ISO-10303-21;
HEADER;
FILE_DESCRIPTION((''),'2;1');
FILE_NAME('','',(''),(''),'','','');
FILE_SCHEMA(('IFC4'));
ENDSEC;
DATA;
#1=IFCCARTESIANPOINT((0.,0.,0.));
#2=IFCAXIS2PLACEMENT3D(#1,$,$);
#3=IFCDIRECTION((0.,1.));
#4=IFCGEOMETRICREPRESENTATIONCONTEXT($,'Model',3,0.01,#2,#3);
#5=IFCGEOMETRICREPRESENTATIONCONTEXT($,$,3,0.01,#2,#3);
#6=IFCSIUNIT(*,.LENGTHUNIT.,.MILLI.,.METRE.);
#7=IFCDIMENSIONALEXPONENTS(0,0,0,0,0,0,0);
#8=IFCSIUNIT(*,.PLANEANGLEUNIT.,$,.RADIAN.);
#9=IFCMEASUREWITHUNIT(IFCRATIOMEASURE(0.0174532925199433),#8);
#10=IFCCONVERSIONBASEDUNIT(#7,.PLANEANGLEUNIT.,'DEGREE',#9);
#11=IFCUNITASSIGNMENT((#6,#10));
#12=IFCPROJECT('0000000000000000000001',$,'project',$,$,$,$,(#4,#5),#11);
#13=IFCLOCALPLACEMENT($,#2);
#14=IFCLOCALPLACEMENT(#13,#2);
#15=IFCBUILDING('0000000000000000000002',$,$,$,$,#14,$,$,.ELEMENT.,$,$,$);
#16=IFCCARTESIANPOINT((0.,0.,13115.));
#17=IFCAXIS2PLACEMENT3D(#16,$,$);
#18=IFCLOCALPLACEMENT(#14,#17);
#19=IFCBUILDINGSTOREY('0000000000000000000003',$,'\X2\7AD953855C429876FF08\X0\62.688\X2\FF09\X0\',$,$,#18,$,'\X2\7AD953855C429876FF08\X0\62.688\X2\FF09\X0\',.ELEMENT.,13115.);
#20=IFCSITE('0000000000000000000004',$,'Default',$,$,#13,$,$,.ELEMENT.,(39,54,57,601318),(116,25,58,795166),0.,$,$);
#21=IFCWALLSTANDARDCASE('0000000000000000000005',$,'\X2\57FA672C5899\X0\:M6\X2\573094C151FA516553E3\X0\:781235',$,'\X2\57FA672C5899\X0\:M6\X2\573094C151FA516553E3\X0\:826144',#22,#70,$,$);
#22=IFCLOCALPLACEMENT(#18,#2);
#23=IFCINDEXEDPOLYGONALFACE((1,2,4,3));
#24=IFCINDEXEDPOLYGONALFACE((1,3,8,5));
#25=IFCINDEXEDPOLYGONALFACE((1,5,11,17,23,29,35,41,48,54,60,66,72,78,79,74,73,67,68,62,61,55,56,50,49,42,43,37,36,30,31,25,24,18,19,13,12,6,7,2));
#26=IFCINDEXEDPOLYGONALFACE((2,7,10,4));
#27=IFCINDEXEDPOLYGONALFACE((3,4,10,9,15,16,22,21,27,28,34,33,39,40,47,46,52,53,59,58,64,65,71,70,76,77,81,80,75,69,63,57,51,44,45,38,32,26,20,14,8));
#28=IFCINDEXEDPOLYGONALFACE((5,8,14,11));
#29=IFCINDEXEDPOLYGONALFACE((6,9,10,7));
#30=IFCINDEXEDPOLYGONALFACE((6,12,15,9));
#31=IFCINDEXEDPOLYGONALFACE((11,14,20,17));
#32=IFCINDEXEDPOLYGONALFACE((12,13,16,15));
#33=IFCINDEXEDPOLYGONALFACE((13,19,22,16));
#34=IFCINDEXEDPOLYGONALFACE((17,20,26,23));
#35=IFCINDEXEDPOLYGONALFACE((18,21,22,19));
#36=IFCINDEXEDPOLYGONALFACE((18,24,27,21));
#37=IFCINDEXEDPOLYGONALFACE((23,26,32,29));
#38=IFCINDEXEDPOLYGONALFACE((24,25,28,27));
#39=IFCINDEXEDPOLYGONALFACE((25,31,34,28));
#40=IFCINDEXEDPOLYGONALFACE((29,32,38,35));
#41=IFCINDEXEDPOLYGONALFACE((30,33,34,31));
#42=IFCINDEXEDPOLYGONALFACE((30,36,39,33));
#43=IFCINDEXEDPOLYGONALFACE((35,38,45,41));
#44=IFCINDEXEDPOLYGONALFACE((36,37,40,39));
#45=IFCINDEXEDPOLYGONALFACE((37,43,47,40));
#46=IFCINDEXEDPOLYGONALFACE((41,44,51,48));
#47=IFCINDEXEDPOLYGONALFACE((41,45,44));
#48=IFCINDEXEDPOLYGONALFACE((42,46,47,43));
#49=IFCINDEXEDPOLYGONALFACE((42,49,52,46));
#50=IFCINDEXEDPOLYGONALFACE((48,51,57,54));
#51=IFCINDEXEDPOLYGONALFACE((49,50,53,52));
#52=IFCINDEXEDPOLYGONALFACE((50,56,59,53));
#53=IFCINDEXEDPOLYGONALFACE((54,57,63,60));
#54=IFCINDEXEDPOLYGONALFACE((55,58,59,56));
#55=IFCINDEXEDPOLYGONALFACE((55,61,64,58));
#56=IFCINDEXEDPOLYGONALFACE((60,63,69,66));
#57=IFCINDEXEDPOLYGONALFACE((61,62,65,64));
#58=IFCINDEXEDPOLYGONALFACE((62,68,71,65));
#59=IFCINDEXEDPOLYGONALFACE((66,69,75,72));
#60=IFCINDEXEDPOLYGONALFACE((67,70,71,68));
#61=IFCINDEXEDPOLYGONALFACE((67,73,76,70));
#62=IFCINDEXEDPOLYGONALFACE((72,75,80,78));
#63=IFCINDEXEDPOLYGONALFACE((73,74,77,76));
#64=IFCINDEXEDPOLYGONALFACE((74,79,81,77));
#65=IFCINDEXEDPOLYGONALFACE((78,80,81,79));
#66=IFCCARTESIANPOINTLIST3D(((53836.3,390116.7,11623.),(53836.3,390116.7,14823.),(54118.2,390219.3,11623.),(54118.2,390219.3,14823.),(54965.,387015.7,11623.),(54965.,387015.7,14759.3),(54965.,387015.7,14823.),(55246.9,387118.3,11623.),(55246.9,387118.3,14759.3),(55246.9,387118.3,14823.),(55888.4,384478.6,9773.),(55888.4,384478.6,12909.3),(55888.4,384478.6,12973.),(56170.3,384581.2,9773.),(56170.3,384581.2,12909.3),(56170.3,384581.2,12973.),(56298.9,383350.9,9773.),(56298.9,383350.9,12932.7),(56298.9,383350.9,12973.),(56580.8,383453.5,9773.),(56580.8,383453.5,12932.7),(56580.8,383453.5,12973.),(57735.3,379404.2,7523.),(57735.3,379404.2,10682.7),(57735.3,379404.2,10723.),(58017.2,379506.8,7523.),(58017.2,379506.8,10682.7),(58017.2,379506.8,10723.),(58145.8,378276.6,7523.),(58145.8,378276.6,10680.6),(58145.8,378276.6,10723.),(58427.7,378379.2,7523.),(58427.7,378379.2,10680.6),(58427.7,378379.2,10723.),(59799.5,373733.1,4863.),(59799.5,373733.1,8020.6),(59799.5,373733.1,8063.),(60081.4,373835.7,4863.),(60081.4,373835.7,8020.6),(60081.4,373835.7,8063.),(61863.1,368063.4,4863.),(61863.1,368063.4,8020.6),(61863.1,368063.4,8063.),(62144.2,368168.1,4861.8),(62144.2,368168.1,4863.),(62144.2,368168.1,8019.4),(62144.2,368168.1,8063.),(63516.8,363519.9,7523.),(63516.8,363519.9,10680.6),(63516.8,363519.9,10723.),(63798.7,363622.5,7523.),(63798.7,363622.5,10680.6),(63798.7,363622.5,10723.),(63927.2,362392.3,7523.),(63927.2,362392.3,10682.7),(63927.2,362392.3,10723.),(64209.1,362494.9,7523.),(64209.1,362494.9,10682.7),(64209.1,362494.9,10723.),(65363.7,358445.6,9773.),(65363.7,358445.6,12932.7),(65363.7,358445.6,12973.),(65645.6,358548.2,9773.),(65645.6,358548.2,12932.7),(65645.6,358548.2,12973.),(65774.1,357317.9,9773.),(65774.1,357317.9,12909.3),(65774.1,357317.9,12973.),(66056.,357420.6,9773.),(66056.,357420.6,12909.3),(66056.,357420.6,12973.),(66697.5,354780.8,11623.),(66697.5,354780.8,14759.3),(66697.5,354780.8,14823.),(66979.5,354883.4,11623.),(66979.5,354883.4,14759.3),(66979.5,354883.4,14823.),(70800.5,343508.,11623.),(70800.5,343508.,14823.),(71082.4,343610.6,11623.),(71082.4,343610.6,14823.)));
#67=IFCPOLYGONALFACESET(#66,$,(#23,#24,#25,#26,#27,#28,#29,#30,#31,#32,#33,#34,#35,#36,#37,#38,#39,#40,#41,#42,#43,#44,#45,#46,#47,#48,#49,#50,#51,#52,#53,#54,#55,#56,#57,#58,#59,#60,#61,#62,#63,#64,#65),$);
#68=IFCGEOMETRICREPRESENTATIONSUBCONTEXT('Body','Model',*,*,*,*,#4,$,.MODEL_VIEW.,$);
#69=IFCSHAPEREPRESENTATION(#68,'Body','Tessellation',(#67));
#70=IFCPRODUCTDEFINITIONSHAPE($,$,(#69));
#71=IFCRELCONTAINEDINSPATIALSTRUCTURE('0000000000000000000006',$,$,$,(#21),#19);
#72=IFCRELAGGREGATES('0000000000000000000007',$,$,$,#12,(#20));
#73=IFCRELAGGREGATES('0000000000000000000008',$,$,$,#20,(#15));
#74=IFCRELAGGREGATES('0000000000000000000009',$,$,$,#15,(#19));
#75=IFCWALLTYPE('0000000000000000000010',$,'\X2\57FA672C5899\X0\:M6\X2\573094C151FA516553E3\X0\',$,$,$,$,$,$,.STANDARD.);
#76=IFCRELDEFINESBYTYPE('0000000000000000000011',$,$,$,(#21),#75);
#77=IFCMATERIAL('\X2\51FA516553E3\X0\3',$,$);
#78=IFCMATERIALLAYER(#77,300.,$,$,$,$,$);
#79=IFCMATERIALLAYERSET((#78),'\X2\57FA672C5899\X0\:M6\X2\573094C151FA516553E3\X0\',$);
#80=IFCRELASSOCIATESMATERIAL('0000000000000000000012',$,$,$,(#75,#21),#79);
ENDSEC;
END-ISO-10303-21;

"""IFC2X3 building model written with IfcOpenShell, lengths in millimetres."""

from ifc_helpers import new_model, entity, si_unit, converted_unit, direction, frame, frame_2d, origin, place, context, subcontext, project, spatial, polyline, rectangle, extrude, clip, bounded_halfspace, material, layer, layer_set, layer_usage, type_object, element, save


model = new_model("IFC2X3")

# Units and contexts
model_context = context("Model", 3, precision=0.01, world=origin(), true_north=direction((0.0, 1.0)))
context_of_model = context(None, 3, precision=0.01, world=origin(), true_north=direction((0.0, 1.0)))
body_context = subcontext(model_context, "Body", "Model", "MODEL_VIEW")
ifc_project = project(units=[si_unit("LENGTHUNIT", "METRE", prefix="MILLI"), converted_unit("PLANEANGLEUNIT", "DEGREE", entity("IfcRatioMeasure", 0.0174532925199433), si_unit("PLANEANGLEUNIT", "RADIAN"), dimensions=[0, 0, 0, 0, 0, 0, 0])], contexts=[model_context, context_of_model])

# Site, building, storey
site_placement = place(None, origin())
site = spatial("IfcSite", under=ifc_project, at=site_placement, Name="Default", CompositionType="ELEMENT", RefLatitude=(39, 54, 57, 601318), RefLongitude=(116, 25, 58, 795166), RefElevation=0.0)
building_placement = place(site_placement, origin())
building = spatial("IfcBuilding", under=site, at=building_placement, CompositionType="ELEMENT")
storey_placement = place(building_placement, frame((0.0, 0.0, 13115.0)))
storey = spatial("IfcBuildingStorey", under=building, at=storey_placement, Name="站厅层顶（62.688）", LongName="站厅层顶（62.688）", CompositionType="ELEMENT", Elevation=13115.0)

# Wall
ifc_material_1 = material(Name="出入口3")
ifc_layer_1 = layer(ifc_material_1, 300.0)
ifc_layer_set_1 = layer_set([ifc_layer_1], Name="基本墙:M6地铁出入口")
ifc_layer_usage_1 = layer_usage(ifc_layer_set_1, "AXIS2", "NEGATIVE", 150.0)
wall_type = type_object("IfcWallType", Name="基本墙:M6地铁出入口", PredefinedType="STANDARD", material=ifc_layer_set_1)
wall_1_placement = place(storey_placement, frame((53977.3, 390168.0, 0.0), z_axis=(0.0, 0.0, 1.0), x_axis=(0.34202, -0.939693, 0.0)))
solid_1 = clip(clip(clip(clip(clip(clip(clip(clip(extrude(rectangle(XDim=49600.0, YDim=300.0, at=frame_2d((24800.0, 0.0), x_axis=(-1.0, 0.0))), origin(), (0.0, 0.0, 1.0), 14823.0), bounded_halfspace(frame((6000.0, -150.0, 12973.0), z_axis=(0.0, 0.0, -1.0), x_axis=(1.0, 0.0, 0.0)), True, frame((6000.0, -150.0, 12973.0)), polyline([(0.0, 0.0), (1200.0, 0.0), (1200.0, 300.0), (0.0, 300.0), (0.0, 0.0)]))), bounded_halfspace(frame((7200.0, -150.0, 12932.7), z_axis=(-0.472221, 0.0, -0.88148), x_axis=(0.88148, 0.0, -0.472221)), True, frame((7200.0, -150.0, 12932.7)), polyline([(0.0, 0.0), (4200.0, 0.0), (4200.0, 300.0), (0.0, 300.0), (0.0, 0.0)]))), bounded_halfspace(frame((11400.0, -150.0, 10723.0), z_axis=(0.0, 0.0, -1.0), x_axis=(1.0, 0.0, 0.0)), True, frame((11400.0, -150.0, 10723.0)), polyline([(0.0, 0.0), (1200.0, 0.0), (1200.0, 300.0), (0.0, 300.0), (0.0, 0.0)]))), bounded_halfspace(frame((12600.0, -150.0, 10680.6), z_axis=(-0.482018, 0.0, -0.876161), x_axis=(0.876161, 0.0, -0.482018)), True, frame((12600.0, -150.0, 10680.6)), polyline([(0.0, 0.0), (4835.1, 0.0), (4835.1, 300.0), (0.0, 300.0), (0.0, 0.0)]))), bounded_halfspace(frame((17435.1, -150.0, 8063.0), z_axis=(0.0, 0.0, -1.0), x_axis=(1.0, 0.0, 0.0)), True, frame((17435.1, -150.0, 8063.0)), polyline([(0.0, 0.0), (6033.6, 0.0), (6031.4, 300.0), (0.0, 300.0), (0.0, 0.0)]))), bounded_halfspace(frame((23468.7, -150.0, 8020.6), z_axis=(0.482018, 0.000002, -0.876161), x_axis=(-0.876161, -0.000004, -0.482018)), True, frame((23468.7, -150.0, 8020.6)), polyline([(0.0, 0.0), (4835.1, 0.0), (4835.1, 300.0), (-2.2, 300.0), (0.0, 0.0)]))), bounded_halfspace(frame((28303.7, -150.0, 10723.0), z_axis=(0.0, 0.0, -1.0), x_axis=(0.000005, -1.0, 0.0)), True, frame((28303.7, -150.0, 10723.0)), polyline([(0.0, 0.0), (1200.0, 0.0), (1200.0, 300.0), (0.0, 300.0), (0.0, 0.0)]))), bounded_halfspace(frame((29503.7, -150.0, 10682.7), z_axis=(0.472221, 0.000002, -0.88148), x_axis=(-0.88148, -0.000004, -0.472221)), True, frame((29503.7, -150.0, 10682.7)), polyline([(0.0, 0.0), (4200.0, 0.0), (4200.0, 300.0), (0.0, 300.0), (0.0, 0.0)])))
solid_2 = clip(clip(clip(clip(clip(clip(clip(clip(solid_1, bounded_halfspace(frame((37603.7, -150.0, 14823.0), z_axis=(0.0, 0.0, -1.0), x_axis=(1.0, 0.000005, 0.0)), True, frame((37603.7, -150.0, 14823.0)), polyline([(0.0, 0.0), (11996.3, 0.0), (11996.3, 300.0), (0.0, 300.0), (0.0, 0.0)]))), bounded_halfspace(frame((3300.0, -150.0, 14759.3), z_axis=(-0.565231, 0.0, -0.824932), x_axis=(0.824932, 0.0, -0.565231)), True, frame((3300.0, -150.0, 14759.3)), polyline([(0.0, 0.0), (2700.0, 0.0), (2700.0, 300.0), (0.0, 300.0), (0.0, 0.0)]))), bounded_halfspace(frame((0.0, -150.0, 14823.0), z_axis=(0.0, 0.0, -1.0), x_axis=(-1.0, 0.0, 0.0)), True, frame((0.0, -150.0, 14823.0)), polyline([(0.0, 0.0), (3300.0, 0.0), (3300.0, 300.0), (0.0, 300.0), (0.0, 0.0)]))), bounded_halfspace(frame((33703.7, -150.0, 12973.0), z_axis=(0.0, 0.0, -1.0), x_axis=(0.000005, -1.0, 0.0)), True, frame((33703.7, -150.0, 12973.0)), polyline([(0.0, 0.0), (1200.0, 0.0), (1200.0, 300.0), (0.0, 300.0), (0.0, 0.0)]))), bounded_halfspace(frame((34903.7, -150.0, 12909.3), z_axis=(0.565231, 0.000003, -0.824932), x_axis=(-0.824932, -0.000004, -0.565231)), True, frame((34903.7, -150.0, 12909.3)), polyline([(0.0, 0.0), (2700.0, 0.0), (2700.0, 300.0), (0.0, 300.0), (0.0, 0.0)]))), bounded_halfspace(frame((34903.7, -150.0, 9773.0), z_axis=(0.0, 0.0, 1.0), x_axis=(-0.000005, 1.0, 0.0)), True, frame((34903.7, -150.0, 9773.0)), polyline([(0.0, 0.0), (0.0, 300.0), (-1200.0, 300.0), (-1200.0, 0.0), (0.0, 0.0)]))), bounded_halfspace(frame((33703.7, -150.0, 9773.0), z_axis=(-0.472221, -0.000002, 0.88148), x_axis=(0.88148, 0.000004, 0.472221)), True, frame((33703.7, -150.0, 9773.0)), polyline([(0.0, 0.0), (0.0, 300.0), (-4200.0, 300.0), (-4200.0, 0.0), (0.0, 0.0)]))), bounded_halfspace(frame((29503.7, -150.0, 7523.0), z_axis=(0.0, 0.0, 1.0), x_axis=(-0.000005, 1.0, 0.0)), True, frame((29503.7, -150.0, 7523.0)), polyline([(0.0, 0.0), (0.0, 300.0), (-1200.0, 300.0), (-1200.0, 0.0), (0.0, 0.0)])))
solid_3 = clip(clip(clip(clip(clip(clip(clip(clip(solid_2, bounded_halfspace(frame((28303.7, -150.0, 7523.0), z_axis=(-0.482018, -0.000002, 0.876161), x_axis=(0.876161, 0.000004, 0.482018)), True, frame((28303.7, -150.0, 7523.0)), polyline([(0.0, 0.0), (0.0, 300.0), (-4837.3, 300.0), (-4835.1, 0.0), (0.0, 0.0)]))), bounded_halfspace(frame((23468.7, -150.0, 4863.0), z_axis=(0.0, 0.0, 1.0), x_axis=(-1.0, 0.0, 0.0)), True, frame((23468.7, -150.0, 4863.0)), polyline([(0.0, 0.0), (-2.2, 300.0), (-6033.6, 300.0), (-6033.6, 0.0), (0.0, 0.0)]))), bounded_halfspace(frame((17435.1, -150.0, 4863.0), z_axis=(0.482018, 0.0, 0.876161), x_axis=(-0.876161, 0.0, 0.482018)), True, frame((17435.1, -150.0, 4863.0)), polyline([(0.0, 0.0), (0.0, 300.0), (-4835.1, 300.0), (-4835.1, 0.0), (0.0, 0.0)]))), bounded_halfspace(frame((12600.0, -150.0, 7523.0), z_axis=(0.0, 0.0, 1.0), x_axis=(-1.0, 0.0, 0.0)), True, frame((12600.0, -150.0, 7523.0)), polyline([(0.0, 0.0), (0.0, 300.0), (-1200.0, 300.0), (-1200.0, 0.0), (0.0, 0.0)]))), bounded_halfspace(frame((11400.0, -150.0, 7523.0), z_axis=(0.472221, 0.0, 0.88148), x_axis=(-0.88148, 0.0, 0.472221)), True, frame((11400.0, -150.0, 7523.0)), polyline([(0.0, 0.0), (0.0, 300.0), (-4200.0, 300.0), (-4200.0, 0.0), (0.0, 0.0)]))), bounded_halfspace(frame((7200.0, -150.0, 9773.0), z_axis=(0.0, 0.0, 1.0), x_axis=(-1.0, 0.0, 0.0)), True, frame((7200.0, -150.0, 9773.0)), polyline([(0.0, 0.0), (0.0, 300.0), (-1200.0, 300.0), (-1200.0, 0.0), (0.0, 0.0)]))), bounded_halfspace(frame((6000.0, -150.0, 9773.0), z_axis=(0.565231, 0.0, 0.824932), x_axis=(-0.824932, 0.0, 0.565231)), True, frame((6000.0, -150.0, 9773.0)), polyline([(0.0, 0.0), (0.0, 300.0), (-2700.0, 300.0), (-2700.0, 0.0), (0.0, 0.0)]))), bounded_halfspace(frame((3300.0, -150.0, 11623.0)), True, frame((3300.0, -150.0, 11623.0)), polyline([(0.0, 0.0), (0.0, 300.0), (-3300.0, 300.0), (-3300.0, 0.0), (0.0, 0.0)])))
element("IfcWallStandardCase", 1, at=wall_1_placement, inside=storey, type_object=wall_type, material=ifc_layer_usage_1, Name="基本墙:M6地铁出入口:781235", ObjectType="基本墙:M6地铁出入口:826144", context=body_context, shape_type="Clipping", body=[
    clip(clip(clip(clip(solid_3, bounded_halfspace(frame((37603.7, -150.0, 11623.0), z_axis=(-0.565231, -0.000003, 0.824932), x_axis=(0.824932, 0.000004, 0.565231)), True, frame((37603.7, -150.0, 11623.0)), polyline([(0.0, 0.0), (0.0, 300.0), (-2700.0, 300.0), (-2700.0, 0.0), (0.0, 0.0)]))), bounded_halfspace(frame((49600.0, -150.0, 11623.0), z_axis=(0.0, 0.0, 1.0), x_axis=(-1.0, -0.000005, 0.0)), True, frame((49600.0, -150.0, 11623.0)), polyline([(0.0, 0.0), (0.0, 300.0), (-11996.3, 300.0), (-11996.3, 0.0), (0.0, 0.0)]))), bounded_halfspace(frame((6000.0, -150.0, 12973.0), z_axis=(0.0, 0.0, -1.0), x_axis=(1.0, 0.0, 0.0)), True, frame((6000.0, -150.0, 12973.0)), polyline([(0.0, 0.0), (1200.0, 0.0), (1200.0, 300.0), (0.0, 300.0), (0.0, 0.0)]))), bounded_halfspace(frame((33703.7, -150.0, 12973.0), z_axis=(0.0, 0.0, -1.0), x_axis=(0.000005, -1.0, 0.0)), True, frame((33703.7, -150.0, 12973.0)), polyline([(0.0, 0.0), (1200.0, 0.0), (1200.0, 300.0), (0.0, 300.0), (0.0, 0.0)]))),
])

save(model, "model.ifc")
